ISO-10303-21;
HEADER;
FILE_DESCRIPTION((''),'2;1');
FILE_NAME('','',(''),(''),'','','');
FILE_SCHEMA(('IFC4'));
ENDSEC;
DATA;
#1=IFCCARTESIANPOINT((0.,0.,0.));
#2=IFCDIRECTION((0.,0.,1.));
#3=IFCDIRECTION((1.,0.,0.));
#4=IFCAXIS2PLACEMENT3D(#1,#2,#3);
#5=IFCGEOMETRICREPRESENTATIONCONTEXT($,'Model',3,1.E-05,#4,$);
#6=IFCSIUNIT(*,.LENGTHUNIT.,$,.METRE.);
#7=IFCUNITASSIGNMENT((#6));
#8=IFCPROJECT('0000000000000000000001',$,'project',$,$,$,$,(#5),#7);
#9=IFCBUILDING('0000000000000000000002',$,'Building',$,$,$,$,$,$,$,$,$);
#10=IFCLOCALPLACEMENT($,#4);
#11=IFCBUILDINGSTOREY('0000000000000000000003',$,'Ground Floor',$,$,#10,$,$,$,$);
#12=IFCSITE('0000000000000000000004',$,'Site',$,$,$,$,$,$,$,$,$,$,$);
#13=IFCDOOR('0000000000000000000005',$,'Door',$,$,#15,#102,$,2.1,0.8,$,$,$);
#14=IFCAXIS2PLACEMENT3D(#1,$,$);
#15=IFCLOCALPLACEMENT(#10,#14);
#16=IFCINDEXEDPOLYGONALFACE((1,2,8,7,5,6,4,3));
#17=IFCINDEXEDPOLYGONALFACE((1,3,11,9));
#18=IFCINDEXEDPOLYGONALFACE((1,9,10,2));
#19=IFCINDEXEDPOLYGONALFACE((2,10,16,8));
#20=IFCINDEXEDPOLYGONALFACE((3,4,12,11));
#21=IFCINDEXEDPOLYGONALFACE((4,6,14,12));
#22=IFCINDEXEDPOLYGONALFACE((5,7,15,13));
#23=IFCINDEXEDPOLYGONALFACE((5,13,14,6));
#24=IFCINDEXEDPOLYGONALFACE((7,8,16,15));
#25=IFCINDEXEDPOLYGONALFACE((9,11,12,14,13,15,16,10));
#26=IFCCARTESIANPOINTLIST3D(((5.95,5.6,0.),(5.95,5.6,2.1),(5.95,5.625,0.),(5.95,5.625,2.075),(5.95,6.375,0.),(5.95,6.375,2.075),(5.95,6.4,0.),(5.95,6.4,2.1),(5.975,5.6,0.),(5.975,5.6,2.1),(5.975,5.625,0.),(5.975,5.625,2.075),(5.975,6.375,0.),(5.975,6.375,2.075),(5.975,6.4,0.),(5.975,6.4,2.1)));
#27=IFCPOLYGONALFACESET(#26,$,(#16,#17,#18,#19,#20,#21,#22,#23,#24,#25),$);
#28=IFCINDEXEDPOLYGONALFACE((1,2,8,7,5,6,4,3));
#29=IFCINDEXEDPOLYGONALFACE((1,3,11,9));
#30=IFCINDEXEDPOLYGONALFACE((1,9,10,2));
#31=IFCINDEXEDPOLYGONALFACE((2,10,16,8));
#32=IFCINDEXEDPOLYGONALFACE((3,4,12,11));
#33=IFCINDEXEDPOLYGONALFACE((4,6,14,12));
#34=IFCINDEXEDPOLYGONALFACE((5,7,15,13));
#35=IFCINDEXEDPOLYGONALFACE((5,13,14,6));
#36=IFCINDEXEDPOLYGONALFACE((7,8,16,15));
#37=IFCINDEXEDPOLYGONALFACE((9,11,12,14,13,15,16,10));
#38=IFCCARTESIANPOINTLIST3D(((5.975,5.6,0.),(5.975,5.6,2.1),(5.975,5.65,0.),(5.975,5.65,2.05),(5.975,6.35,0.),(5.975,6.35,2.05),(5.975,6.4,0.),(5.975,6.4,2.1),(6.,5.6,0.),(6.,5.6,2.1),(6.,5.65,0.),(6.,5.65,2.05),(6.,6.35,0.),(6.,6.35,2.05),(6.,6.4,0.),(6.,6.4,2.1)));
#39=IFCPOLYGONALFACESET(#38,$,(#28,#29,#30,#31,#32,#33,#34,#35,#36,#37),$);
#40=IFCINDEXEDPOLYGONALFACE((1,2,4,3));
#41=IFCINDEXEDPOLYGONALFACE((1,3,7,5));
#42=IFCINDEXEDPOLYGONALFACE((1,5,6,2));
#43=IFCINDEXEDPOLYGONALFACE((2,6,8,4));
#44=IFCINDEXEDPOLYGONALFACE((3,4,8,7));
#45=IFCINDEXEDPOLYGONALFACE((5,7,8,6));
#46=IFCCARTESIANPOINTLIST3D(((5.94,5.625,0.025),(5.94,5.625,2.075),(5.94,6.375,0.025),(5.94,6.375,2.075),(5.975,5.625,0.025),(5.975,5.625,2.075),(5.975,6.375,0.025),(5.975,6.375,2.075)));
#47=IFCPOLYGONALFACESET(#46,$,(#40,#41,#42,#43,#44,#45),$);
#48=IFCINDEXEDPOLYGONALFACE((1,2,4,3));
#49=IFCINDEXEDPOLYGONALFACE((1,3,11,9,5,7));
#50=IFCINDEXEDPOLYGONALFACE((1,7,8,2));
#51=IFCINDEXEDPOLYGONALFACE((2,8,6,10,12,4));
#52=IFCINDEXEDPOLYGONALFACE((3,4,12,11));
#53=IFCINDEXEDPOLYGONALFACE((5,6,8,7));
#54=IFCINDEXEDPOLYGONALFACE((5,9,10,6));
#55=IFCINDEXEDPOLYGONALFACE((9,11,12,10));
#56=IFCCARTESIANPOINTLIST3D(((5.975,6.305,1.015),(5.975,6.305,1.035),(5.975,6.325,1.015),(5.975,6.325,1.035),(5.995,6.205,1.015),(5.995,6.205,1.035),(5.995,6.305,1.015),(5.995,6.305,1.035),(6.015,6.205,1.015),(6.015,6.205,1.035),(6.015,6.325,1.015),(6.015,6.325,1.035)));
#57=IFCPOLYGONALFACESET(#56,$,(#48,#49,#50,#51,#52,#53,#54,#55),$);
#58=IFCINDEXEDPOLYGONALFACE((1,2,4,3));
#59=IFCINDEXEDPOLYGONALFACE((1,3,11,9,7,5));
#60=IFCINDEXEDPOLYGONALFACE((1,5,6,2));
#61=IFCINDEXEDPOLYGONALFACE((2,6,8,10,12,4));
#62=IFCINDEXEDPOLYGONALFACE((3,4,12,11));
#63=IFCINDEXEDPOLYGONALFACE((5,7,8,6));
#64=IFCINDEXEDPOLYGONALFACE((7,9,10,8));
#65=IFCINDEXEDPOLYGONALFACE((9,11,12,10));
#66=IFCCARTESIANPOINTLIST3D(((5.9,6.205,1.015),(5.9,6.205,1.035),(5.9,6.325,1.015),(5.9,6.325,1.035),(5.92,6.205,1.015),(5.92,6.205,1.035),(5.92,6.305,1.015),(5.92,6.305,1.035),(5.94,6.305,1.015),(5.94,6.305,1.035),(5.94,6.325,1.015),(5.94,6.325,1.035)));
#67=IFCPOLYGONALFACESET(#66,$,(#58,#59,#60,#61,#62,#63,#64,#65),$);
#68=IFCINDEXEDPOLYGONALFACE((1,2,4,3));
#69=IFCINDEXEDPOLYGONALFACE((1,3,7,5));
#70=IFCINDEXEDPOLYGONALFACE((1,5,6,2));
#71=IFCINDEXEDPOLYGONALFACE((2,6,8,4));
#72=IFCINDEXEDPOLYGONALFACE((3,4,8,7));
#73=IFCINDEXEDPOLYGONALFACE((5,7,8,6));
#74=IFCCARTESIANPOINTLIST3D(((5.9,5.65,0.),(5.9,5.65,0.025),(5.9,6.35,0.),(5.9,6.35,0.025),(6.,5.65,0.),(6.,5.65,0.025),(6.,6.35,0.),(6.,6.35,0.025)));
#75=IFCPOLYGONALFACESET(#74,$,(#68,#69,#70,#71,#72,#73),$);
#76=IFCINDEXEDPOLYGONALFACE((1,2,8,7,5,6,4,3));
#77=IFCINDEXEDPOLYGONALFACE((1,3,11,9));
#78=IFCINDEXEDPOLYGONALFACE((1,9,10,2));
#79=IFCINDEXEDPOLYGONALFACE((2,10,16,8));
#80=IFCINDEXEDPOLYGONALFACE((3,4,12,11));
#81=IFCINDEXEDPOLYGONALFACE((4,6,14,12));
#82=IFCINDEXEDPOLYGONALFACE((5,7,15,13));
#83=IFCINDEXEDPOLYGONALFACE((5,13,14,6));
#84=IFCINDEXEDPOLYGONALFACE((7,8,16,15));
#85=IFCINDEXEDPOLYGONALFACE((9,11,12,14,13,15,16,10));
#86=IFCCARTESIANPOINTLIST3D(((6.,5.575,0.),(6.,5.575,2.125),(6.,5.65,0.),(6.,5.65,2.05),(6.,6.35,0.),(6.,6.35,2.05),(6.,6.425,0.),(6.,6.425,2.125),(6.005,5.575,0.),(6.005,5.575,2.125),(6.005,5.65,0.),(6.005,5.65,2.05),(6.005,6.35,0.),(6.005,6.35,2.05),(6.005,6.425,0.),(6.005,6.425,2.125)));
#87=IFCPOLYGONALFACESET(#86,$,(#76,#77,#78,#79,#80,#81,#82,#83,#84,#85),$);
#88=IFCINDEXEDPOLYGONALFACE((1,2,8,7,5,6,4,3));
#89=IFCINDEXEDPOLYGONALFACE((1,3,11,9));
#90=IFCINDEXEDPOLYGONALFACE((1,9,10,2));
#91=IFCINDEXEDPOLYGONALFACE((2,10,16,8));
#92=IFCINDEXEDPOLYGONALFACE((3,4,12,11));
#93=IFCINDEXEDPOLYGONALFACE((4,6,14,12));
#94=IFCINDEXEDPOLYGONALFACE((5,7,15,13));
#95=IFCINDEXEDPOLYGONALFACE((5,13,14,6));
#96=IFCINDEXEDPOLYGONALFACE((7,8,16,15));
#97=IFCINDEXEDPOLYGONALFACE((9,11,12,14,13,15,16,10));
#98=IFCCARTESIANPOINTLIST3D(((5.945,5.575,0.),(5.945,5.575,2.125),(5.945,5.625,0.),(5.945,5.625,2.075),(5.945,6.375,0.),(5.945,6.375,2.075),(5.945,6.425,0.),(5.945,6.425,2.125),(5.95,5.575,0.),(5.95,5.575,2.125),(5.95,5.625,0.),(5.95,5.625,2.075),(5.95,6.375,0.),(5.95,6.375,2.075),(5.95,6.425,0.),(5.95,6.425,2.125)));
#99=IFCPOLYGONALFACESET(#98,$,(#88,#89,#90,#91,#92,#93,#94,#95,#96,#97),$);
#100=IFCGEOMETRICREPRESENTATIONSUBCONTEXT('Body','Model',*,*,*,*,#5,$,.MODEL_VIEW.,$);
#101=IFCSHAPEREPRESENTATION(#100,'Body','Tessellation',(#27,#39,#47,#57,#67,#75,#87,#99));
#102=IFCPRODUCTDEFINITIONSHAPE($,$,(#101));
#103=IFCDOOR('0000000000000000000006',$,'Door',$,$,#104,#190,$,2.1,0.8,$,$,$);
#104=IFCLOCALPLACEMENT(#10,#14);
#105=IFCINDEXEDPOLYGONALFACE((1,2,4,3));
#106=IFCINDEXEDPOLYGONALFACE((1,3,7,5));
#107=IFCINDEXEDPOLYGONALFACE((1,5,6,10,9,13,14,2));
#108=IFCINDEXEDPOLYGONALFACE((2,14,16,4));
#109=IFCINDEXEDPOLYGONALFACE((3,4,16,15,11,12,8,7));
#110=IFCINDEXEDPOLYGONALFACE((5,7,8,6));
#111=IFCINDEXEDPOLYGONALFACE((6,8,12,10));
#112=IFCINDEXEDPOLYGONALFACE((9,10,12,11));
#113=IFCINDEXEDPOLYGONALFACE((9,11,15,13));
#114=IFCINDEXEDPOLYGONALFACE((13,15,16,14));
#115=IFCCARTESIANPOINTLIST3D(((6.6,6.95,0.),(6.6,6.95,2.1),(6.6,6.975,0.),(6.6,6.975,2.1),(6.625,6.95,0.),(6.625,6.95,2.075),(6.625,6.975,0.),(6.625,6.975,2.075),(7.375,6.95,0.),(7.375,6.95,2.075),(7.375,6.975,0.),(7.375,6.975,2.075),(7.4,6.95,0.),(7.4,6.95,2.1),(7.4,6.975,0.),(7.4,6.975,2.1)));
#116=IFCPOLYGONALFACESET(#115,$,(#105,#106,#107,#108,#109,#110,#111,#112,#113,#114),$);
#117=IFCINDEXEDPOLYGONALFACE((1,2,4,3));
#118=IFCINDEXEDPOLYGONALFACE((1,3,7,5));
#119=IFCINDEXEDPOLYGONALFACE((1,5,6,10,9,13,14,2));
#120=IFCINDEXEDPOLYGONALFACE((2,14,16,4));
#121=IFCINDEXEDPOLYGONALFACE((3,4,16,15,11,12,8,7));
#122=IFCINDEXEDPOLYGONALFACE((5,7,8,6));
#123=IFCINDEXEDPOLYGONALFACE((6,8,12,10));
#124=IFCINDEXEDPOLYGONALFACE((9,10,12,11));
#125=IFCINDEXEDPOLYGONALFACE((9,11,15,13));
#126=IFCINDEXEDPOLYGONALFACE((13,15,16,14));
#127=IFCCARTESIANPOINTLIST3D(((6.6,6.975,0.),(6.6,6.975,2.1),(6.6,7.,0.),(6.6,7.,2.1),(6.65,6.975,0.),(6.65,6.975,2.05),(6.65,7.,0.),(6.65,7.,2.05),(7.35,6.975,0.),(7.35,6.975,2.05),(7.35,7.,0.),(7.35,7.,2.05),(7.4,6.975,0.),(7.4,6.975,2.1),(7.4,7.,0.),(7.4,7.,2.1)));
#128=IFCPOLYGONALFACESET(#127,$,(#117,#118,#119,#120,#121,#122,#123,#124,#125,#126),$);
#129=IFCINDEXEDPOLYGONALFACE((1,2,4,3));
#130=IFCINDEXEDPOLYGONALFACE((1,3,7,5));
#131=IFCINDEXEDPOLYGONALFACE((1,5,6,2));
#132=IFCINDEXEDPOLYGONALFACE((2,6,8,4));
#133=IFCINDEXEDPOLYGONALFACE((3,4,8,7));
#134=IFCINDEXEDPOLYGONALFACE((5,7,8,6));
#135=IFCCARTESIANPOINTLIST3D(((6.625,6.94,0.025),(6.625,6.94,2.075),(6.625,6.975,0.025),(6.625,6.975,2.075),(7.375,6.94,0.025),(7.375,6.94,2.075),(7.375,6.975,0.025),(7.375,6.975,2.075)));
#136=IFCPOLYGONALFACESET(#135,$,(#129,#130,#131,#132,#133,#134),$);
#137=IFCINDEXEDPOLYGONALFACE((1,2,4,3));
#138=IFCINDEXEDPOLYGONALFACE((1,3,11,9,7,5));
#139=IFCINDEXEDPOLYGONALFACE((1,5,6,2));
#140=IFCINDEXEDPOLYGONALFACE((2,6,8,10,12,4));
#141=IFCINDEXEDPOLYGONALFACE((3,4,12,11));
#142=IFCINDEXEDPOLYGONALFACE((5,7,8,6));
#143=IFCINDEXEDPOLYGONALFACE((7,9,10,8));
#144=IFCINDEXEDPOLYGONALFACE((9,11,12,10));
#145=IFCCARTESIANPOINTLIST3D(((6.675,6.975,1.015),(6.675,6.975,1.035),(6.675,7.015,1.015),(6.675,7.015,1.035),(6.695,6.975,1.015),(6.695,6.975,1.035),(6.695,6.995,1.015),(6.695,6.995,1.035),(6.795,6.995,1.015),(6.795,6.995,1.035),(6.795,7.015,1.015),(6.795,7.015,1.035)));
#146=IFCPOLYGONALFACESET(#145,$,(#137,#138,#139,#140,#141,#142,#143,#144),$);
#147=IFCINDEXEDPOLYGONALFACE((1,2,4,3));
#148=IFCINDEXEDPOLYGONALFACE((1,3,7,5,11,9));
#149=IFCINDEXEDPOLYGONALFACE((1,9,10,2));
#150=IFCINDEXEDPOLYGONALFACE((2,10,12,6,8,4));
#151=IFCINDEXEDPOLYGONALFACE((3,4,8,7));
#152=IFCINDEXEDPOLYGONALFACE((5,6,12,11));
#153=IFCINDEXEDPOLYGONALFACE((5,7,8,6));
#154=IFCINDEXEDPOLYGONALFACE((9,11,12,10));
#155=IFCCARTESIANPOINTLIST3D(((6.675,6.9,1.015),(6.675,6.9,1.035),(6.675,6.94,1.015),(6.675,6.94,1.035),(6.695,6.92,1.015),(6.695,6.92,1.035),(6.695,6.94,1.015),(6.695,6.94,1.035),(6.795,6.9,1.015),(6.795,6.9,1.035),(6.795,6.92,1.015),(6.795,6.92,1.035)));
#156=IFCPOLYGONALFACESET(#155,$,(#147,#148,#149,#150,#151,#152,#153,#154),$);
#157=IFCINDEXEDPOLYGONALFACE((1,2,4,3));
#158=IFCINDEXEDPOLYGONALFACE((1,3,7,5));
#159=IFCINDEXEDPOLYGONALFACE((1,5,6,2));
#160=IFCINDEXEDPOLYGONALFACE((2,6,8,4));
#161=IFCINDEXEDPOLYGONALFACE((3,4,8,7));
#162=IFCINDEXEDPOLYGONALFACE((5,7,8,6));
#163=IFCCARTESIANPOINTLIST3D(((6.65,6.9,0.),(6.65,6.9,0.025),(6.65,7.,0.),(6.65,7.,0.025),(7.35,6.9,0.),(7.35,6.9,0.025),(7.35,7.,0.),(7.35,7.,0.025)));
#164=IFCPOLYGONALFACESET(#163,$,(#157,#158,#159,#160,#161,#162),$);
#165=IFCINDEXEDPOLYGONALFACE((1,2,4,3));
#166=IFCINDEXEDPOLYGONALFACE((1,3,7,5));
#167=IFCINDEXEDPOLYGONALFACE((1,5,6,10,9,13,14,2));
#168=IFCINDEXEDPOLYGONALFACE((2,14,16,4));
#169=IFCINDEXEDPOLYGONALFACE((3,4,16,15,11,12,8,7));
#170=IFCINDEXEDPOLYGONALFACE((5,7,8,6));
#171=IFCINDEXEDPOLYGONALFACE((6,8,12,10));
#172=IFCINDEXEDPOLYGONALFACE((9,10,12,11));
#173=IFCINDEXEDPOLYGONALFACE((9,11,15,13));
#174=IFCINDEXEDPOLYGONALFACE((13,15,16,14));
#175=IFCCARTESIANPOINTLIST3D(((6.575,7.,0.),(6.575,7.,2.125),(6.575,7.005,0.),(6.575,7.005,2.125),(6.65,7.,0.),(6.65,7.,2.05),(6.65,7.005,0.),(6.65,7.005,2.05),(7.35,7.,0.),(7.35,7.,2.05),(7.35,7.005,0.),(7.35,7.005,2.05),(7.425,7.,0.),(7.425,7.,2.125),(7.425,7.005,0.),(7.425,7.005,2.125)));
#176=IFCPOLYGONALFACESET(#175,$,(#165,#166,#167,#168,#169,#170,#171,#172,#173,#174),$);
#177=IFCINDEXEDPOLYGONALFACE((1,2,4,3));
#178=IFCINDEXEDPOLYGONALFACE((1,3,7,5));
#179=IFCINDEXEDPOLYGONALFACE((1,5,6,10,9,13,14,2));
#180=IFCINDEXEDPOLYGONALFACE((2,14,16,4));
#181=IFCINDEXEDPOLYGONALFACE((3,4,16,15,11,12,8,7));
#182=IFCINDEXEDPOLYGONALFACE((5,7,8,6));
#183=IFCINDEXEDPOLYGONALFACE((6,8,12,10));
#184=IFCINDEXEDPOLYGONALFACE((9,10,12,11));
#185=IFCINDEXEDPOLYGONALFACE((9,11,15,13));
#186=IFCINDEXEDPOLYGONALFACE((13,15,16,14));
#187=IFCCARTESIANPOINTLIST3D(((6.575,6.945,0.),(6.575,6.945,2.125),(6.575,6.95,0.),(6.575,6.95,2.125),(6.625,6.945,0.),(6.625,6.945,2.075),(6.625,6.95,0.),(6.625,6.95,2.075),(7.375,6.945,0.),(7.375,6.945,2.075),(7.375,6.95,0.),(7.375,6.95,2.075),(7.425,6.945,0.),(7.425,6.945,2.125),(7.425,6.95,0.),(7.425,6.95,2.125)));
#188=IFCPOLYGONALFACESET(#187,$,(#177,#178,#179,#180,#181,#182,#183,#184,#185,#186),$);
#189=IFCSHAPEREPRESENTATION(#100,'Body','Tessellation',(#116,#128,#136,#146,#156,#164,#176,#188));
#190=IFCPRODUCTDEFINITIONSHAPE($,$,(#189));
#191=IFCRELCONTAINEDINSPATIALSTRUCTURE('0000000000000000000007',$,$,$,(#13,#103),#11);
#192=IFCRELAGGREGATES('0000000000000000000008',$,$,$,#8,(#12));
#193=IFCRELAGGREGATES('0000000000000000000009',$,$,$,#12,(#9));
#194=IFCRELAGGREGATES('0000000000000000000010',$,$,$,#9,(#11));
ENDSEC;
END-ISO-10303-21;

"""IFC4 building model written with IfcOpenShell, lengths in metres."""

from ifc_helpers import new_model, si_unit, frame, origin_with_axes, place, context, subcontext, project, spatial, line, indexed_curve, outline, extrude, element, save


model = new_model("IFC4")

# Units and contexts
model_context = context("Model", 3, precision=1e-05, world=origin_with_axes())
body_context = subcontext(model_context, "Body", "Model", "MODEL_VIEW")
ifc_project = project(units=[si_unit("LENGTHUNIT", "METRE")], contexts=[model_context])

# Site, building, storey
site = spatial("IfcSite", under=ifc_project, Name="Site")
building = spatial("IfcBuilding", under=site, Name="Building")
storey_placement = place(None, origin_with_axes())
storey = spatial("IfcBuildingStorey", under=building, at=storey_placement, Name="Ground Floor")

# Doors
door_1_placement = place(storey_placement, frame((6.0, 5.6, 0.0), z_axis=(0.0, 0.0, 1.0), x_axis=(0.0, 1.0, 0.0)))
element("IfcDoor", 1, at=door_1_placement, inside=storey, Name="Door", OverallHeight=2.1, OverallWidth=0.8, context=body_context, shape_type="SweptSolid", body=[
    extrude(outline(indexed_curve([(0.0, 0.0), (0.0, 2.1), (0.8, 2.1), (0.8, 0.0), (0.775, 0.0), (0.775, 2.075), (0.025, 2.075), (0.025, 0.0)], segments=[line(1, 2, 3, 4, 5, 6, 7, 8, 1)])), frame((0.0, 0.025, 0.0), z_axis=(0.0, -1.0, 0.0), x_axis=(1.0, 0.0, 0.0)), (0.0, 0.0, -1.0), 0.025),
    extrude(outline(indexed_curve([(0.0, 0.0), (0.0, 2.1), (0.8, 2.1), (0.8, 0.0), (0.75, 0.0), (0.75, 2.05), (0.05, 2.05), (0.05, 0.0)], segments=[line(1, 2, 3, 4, 5, 6, 7, 8, 1)])), frame((0.0, 0.0, 0.0), z_axis=(0.0, -1.0, 0.0), x_axis=(1.0, 0.0, 0.0)), (0.0, 0.0, -1.0), 0.025),
    extrude(outline(indexed_curve([(0.0, 0.0), (0.75, 0.0), (0.75, 0.035), (0.0, 0.035)], segments=[line(1, 2, 3, 4, 1)])), frame((0.025, 0.025, 0.025), z_axis=(0.0, 0.0, 1.0), x_axis=(1.0, 0.0, 0.0)), (0.0, 0.0, 1.0), 2.05),
    extrude(outline(indexed_curve([(0.0, 0.0), (0.0, -0.04), (-0.12, -0.04), (-0.12, -0.02), (-0.02, -0.02), (-0.02, 0.0)], segments=[line(1, 2, 3, 4, 5, 6, 1)])), frame((0.725, 0.025, 1.015), z_axis=(0.0, 0.0, 1.0), x_axis=(1.0, 0.0, 0.0)), (0.0, 0.0, 1.0), 0.02),
    extrude(outline(indexed_curve([(0.0, 0.0), (0.0, 0.04), (-0.12, 0.04), (-0.12, 0.02), (-0.02, 0.02), (-0.02, 0.0)], segments=[line(1, 2, 3, 4, 5, 6, 1)])), frame((0.725, 0.06, 1.015), z_axis=(0.0, 0.0, 1.0), x_axis=(1.0, 0.0, 0.0)), (0.0, 0.0, 1.0), 0.02),
    extrude(outline(indexed_curve([(0.0, 0.0), (0.7, 0.0), (0.7, 0.1), (0.0, 0.1)], segments=[line(1, 2, 3, 4, 1)])), frame((0.05, 0.0, 0.0), z_axis=(0.0, 0.0, 1.0), x_axis=(1.0, 0.0, 0.0)), (0.0, 0.0, 1.0), 0.025),
    extrude(outline(indexed_curve([(0.0, 0.0), (0.0, 2.125), (0.85, 2.125), (0.85, 0.0), (0.775, 0.0), (0.775, 2.05), (0.075, 2.05), (0.075, 0.0)], segments=[line(1, 2, 3, 4, 5, 6, 7, 8, 1)])), frame((-0.025, -0.005, 0.0), z_axis=(0.0, -1.0, 0.0), x_axis=(1.0, 0.0, 0.0)), (0.0, 0.0, -1.0), 0.005),
    extrude(outline(indexed_curve([(0.0, 0.0), (0.0, 2.125), (0.85, 2.125), (0.85, 0.0), (0.8, 0.0), (0.8, 2.075), (0.05, 2.075), (0.05, 0.0)], segments=[line(1, 2, 3, 4, 5, 6, 7, 8, 1)])), frame((-0.025, 0.05, 0.0), z_axis=(0.0, -1.0, 0.0), x_axis=(1.0, 0.0, 0.0)), (0.0, 0.0, -1.0), 0.005),
])
door_2_placement = place(storey_placement, frame((7.4, 7.0, 0.0), z_axis=(0.0, 0.0, 1.0), x_axis=(-1.0, 0.0, 0.0)))
element("IfcDoor", 2, at=door_2_placement, inside=storey, Name="Door", OverallHeight=2.1, OverallWidth=0.8, context=body_context, shape_type="SweptSolid", body=[
    extrude(outline(indexed_curve([(0.0, 0.0), (0.0, 2.1), (0.8, 2.1), (0.8, 0.0), (0.775, 0.0), (0.775, 2.075), (0.025, 2.075), (0.025, 0.0)], segments=[line(1, 2, 3, 4, 5, 6, 7, 8, 1)])), frame((0.0, 0.025, 0.0), z_axis=(0.0, -1.0, 0.0), x_axis=(1.0, 0.0, 0.0)), (0.0, 0.0, -1.0), 0.025),
    extrude(outline(indexed_curve([(0.0, 0.0), (0.0, 2.1), (0.8, 2.1), (0.8, 0.0), (0.75, 0.0), (0.75, 2.05), (0.05, 2.05), (0.05, 0.0)], segments=[line(1, 2, 3, 4, 5, 6, 7, 8, 1)])), frame((0.0, 0.0, 0.0), z_axis=(0.0, -1.0, 0.0), x_axis=(1.0, 0.0, 0.0)), (0.0, 0.0, -1.0), 0.025),
    extrude(outline(indexed_curve([(0.0, 0.0), (0.75, 0.0), (0.75, 0.035), (0.0, 0.035)], segments=[line(1, 2, 3, 4, 1)])), frame((0.025, 0.025, 0.025), z_axis=(0.0, 0.0, 1.0), x_axis=(1.0, 0.0, 0.0)), (0.0, 0.0, 1.0), 2.05),
    extrude(outline(indexed_curve([(0.0, 0.0), (0.0, -0.04), (-0.12, -0.04), (-0.12, -0.02), (-0.02, -0.02), (-0.02, 0.0)], segments=[line(1, 2, 3, 4, 5, 6, 1)])), frame((0.725, 0.025, 1.015), z_axis=(0.0, 0.0, 1.0), x_axis=(1.0, 0.0, 0.0)), (0.0, 0.0, 1.0), 0.02),
    extrude(outline(indexed_curve([(0.0, 0.0), (0.0, 0.04), (-0.12, 0.04), (-0.12, 0.02), (-0.02, 0.02), (-0.02, 0.0)], segments=[line(1, 2, 3, 4, 5, 6, 1)])), frame((0.725, 0.06, 1.015), z_axis=(0.0, 0.0, 1.0), x_axis=(1.0, 0.0, 0.0)), (0.0, 0.0, 1.0), 0.02),
    extrude(outline(indexed_curve([(0.0, 0.0), (0.7, 0.0), (0.7, 0.1), (0.0, 0.1)], segments=[line(1, 2, 3, 4, 1)])), frame((0.05, 0.0, 0.0), z_axis=(0.0, 0.0, 1.0), x_axis=(1.0, 0.0, 0.0)), (0.0, 0.0, 1.0), 0.025),
    extrude(outline(indexed_curve([(0.0, 0.0), (0.0, 2.125), (0.85, 2.125), (0.85, 0.0), (0.775, 0.0), (0.775, 2.05), (0.075, 2.05), (0.075, 0.0)], segments=[line(1, 2, 3, 4, 5, 6, 7, 8, 1)])), frame((-0.025, -0.005, 0.0), z_axis=(0.0, -1.0, 0.0), x_axis=(1.0, 0.0, 0.0)), (0.0, 0.0, -1.0), 0.005),
    extrude(outline(indexed_curve([(0.0, 0.0), (0.0, 2.125), (0.85, 2.125), (0.85, 0.0), (0.8, 0.0), (0.8, 2.075), (0.05, 2.075), (0.05, 0.0)], segments=[line(1, 2, 3, 4, 5, 6, 7, 8, 1)])), frame((-0.025, 0.05, 0.0), z_axis=(0.0, -1.0, 0.0), x_axis=(1.0, 0.0, 0.0)), (0.0, 0.0, -1.0), 0.005),
])

save(model, "model.ifc")
